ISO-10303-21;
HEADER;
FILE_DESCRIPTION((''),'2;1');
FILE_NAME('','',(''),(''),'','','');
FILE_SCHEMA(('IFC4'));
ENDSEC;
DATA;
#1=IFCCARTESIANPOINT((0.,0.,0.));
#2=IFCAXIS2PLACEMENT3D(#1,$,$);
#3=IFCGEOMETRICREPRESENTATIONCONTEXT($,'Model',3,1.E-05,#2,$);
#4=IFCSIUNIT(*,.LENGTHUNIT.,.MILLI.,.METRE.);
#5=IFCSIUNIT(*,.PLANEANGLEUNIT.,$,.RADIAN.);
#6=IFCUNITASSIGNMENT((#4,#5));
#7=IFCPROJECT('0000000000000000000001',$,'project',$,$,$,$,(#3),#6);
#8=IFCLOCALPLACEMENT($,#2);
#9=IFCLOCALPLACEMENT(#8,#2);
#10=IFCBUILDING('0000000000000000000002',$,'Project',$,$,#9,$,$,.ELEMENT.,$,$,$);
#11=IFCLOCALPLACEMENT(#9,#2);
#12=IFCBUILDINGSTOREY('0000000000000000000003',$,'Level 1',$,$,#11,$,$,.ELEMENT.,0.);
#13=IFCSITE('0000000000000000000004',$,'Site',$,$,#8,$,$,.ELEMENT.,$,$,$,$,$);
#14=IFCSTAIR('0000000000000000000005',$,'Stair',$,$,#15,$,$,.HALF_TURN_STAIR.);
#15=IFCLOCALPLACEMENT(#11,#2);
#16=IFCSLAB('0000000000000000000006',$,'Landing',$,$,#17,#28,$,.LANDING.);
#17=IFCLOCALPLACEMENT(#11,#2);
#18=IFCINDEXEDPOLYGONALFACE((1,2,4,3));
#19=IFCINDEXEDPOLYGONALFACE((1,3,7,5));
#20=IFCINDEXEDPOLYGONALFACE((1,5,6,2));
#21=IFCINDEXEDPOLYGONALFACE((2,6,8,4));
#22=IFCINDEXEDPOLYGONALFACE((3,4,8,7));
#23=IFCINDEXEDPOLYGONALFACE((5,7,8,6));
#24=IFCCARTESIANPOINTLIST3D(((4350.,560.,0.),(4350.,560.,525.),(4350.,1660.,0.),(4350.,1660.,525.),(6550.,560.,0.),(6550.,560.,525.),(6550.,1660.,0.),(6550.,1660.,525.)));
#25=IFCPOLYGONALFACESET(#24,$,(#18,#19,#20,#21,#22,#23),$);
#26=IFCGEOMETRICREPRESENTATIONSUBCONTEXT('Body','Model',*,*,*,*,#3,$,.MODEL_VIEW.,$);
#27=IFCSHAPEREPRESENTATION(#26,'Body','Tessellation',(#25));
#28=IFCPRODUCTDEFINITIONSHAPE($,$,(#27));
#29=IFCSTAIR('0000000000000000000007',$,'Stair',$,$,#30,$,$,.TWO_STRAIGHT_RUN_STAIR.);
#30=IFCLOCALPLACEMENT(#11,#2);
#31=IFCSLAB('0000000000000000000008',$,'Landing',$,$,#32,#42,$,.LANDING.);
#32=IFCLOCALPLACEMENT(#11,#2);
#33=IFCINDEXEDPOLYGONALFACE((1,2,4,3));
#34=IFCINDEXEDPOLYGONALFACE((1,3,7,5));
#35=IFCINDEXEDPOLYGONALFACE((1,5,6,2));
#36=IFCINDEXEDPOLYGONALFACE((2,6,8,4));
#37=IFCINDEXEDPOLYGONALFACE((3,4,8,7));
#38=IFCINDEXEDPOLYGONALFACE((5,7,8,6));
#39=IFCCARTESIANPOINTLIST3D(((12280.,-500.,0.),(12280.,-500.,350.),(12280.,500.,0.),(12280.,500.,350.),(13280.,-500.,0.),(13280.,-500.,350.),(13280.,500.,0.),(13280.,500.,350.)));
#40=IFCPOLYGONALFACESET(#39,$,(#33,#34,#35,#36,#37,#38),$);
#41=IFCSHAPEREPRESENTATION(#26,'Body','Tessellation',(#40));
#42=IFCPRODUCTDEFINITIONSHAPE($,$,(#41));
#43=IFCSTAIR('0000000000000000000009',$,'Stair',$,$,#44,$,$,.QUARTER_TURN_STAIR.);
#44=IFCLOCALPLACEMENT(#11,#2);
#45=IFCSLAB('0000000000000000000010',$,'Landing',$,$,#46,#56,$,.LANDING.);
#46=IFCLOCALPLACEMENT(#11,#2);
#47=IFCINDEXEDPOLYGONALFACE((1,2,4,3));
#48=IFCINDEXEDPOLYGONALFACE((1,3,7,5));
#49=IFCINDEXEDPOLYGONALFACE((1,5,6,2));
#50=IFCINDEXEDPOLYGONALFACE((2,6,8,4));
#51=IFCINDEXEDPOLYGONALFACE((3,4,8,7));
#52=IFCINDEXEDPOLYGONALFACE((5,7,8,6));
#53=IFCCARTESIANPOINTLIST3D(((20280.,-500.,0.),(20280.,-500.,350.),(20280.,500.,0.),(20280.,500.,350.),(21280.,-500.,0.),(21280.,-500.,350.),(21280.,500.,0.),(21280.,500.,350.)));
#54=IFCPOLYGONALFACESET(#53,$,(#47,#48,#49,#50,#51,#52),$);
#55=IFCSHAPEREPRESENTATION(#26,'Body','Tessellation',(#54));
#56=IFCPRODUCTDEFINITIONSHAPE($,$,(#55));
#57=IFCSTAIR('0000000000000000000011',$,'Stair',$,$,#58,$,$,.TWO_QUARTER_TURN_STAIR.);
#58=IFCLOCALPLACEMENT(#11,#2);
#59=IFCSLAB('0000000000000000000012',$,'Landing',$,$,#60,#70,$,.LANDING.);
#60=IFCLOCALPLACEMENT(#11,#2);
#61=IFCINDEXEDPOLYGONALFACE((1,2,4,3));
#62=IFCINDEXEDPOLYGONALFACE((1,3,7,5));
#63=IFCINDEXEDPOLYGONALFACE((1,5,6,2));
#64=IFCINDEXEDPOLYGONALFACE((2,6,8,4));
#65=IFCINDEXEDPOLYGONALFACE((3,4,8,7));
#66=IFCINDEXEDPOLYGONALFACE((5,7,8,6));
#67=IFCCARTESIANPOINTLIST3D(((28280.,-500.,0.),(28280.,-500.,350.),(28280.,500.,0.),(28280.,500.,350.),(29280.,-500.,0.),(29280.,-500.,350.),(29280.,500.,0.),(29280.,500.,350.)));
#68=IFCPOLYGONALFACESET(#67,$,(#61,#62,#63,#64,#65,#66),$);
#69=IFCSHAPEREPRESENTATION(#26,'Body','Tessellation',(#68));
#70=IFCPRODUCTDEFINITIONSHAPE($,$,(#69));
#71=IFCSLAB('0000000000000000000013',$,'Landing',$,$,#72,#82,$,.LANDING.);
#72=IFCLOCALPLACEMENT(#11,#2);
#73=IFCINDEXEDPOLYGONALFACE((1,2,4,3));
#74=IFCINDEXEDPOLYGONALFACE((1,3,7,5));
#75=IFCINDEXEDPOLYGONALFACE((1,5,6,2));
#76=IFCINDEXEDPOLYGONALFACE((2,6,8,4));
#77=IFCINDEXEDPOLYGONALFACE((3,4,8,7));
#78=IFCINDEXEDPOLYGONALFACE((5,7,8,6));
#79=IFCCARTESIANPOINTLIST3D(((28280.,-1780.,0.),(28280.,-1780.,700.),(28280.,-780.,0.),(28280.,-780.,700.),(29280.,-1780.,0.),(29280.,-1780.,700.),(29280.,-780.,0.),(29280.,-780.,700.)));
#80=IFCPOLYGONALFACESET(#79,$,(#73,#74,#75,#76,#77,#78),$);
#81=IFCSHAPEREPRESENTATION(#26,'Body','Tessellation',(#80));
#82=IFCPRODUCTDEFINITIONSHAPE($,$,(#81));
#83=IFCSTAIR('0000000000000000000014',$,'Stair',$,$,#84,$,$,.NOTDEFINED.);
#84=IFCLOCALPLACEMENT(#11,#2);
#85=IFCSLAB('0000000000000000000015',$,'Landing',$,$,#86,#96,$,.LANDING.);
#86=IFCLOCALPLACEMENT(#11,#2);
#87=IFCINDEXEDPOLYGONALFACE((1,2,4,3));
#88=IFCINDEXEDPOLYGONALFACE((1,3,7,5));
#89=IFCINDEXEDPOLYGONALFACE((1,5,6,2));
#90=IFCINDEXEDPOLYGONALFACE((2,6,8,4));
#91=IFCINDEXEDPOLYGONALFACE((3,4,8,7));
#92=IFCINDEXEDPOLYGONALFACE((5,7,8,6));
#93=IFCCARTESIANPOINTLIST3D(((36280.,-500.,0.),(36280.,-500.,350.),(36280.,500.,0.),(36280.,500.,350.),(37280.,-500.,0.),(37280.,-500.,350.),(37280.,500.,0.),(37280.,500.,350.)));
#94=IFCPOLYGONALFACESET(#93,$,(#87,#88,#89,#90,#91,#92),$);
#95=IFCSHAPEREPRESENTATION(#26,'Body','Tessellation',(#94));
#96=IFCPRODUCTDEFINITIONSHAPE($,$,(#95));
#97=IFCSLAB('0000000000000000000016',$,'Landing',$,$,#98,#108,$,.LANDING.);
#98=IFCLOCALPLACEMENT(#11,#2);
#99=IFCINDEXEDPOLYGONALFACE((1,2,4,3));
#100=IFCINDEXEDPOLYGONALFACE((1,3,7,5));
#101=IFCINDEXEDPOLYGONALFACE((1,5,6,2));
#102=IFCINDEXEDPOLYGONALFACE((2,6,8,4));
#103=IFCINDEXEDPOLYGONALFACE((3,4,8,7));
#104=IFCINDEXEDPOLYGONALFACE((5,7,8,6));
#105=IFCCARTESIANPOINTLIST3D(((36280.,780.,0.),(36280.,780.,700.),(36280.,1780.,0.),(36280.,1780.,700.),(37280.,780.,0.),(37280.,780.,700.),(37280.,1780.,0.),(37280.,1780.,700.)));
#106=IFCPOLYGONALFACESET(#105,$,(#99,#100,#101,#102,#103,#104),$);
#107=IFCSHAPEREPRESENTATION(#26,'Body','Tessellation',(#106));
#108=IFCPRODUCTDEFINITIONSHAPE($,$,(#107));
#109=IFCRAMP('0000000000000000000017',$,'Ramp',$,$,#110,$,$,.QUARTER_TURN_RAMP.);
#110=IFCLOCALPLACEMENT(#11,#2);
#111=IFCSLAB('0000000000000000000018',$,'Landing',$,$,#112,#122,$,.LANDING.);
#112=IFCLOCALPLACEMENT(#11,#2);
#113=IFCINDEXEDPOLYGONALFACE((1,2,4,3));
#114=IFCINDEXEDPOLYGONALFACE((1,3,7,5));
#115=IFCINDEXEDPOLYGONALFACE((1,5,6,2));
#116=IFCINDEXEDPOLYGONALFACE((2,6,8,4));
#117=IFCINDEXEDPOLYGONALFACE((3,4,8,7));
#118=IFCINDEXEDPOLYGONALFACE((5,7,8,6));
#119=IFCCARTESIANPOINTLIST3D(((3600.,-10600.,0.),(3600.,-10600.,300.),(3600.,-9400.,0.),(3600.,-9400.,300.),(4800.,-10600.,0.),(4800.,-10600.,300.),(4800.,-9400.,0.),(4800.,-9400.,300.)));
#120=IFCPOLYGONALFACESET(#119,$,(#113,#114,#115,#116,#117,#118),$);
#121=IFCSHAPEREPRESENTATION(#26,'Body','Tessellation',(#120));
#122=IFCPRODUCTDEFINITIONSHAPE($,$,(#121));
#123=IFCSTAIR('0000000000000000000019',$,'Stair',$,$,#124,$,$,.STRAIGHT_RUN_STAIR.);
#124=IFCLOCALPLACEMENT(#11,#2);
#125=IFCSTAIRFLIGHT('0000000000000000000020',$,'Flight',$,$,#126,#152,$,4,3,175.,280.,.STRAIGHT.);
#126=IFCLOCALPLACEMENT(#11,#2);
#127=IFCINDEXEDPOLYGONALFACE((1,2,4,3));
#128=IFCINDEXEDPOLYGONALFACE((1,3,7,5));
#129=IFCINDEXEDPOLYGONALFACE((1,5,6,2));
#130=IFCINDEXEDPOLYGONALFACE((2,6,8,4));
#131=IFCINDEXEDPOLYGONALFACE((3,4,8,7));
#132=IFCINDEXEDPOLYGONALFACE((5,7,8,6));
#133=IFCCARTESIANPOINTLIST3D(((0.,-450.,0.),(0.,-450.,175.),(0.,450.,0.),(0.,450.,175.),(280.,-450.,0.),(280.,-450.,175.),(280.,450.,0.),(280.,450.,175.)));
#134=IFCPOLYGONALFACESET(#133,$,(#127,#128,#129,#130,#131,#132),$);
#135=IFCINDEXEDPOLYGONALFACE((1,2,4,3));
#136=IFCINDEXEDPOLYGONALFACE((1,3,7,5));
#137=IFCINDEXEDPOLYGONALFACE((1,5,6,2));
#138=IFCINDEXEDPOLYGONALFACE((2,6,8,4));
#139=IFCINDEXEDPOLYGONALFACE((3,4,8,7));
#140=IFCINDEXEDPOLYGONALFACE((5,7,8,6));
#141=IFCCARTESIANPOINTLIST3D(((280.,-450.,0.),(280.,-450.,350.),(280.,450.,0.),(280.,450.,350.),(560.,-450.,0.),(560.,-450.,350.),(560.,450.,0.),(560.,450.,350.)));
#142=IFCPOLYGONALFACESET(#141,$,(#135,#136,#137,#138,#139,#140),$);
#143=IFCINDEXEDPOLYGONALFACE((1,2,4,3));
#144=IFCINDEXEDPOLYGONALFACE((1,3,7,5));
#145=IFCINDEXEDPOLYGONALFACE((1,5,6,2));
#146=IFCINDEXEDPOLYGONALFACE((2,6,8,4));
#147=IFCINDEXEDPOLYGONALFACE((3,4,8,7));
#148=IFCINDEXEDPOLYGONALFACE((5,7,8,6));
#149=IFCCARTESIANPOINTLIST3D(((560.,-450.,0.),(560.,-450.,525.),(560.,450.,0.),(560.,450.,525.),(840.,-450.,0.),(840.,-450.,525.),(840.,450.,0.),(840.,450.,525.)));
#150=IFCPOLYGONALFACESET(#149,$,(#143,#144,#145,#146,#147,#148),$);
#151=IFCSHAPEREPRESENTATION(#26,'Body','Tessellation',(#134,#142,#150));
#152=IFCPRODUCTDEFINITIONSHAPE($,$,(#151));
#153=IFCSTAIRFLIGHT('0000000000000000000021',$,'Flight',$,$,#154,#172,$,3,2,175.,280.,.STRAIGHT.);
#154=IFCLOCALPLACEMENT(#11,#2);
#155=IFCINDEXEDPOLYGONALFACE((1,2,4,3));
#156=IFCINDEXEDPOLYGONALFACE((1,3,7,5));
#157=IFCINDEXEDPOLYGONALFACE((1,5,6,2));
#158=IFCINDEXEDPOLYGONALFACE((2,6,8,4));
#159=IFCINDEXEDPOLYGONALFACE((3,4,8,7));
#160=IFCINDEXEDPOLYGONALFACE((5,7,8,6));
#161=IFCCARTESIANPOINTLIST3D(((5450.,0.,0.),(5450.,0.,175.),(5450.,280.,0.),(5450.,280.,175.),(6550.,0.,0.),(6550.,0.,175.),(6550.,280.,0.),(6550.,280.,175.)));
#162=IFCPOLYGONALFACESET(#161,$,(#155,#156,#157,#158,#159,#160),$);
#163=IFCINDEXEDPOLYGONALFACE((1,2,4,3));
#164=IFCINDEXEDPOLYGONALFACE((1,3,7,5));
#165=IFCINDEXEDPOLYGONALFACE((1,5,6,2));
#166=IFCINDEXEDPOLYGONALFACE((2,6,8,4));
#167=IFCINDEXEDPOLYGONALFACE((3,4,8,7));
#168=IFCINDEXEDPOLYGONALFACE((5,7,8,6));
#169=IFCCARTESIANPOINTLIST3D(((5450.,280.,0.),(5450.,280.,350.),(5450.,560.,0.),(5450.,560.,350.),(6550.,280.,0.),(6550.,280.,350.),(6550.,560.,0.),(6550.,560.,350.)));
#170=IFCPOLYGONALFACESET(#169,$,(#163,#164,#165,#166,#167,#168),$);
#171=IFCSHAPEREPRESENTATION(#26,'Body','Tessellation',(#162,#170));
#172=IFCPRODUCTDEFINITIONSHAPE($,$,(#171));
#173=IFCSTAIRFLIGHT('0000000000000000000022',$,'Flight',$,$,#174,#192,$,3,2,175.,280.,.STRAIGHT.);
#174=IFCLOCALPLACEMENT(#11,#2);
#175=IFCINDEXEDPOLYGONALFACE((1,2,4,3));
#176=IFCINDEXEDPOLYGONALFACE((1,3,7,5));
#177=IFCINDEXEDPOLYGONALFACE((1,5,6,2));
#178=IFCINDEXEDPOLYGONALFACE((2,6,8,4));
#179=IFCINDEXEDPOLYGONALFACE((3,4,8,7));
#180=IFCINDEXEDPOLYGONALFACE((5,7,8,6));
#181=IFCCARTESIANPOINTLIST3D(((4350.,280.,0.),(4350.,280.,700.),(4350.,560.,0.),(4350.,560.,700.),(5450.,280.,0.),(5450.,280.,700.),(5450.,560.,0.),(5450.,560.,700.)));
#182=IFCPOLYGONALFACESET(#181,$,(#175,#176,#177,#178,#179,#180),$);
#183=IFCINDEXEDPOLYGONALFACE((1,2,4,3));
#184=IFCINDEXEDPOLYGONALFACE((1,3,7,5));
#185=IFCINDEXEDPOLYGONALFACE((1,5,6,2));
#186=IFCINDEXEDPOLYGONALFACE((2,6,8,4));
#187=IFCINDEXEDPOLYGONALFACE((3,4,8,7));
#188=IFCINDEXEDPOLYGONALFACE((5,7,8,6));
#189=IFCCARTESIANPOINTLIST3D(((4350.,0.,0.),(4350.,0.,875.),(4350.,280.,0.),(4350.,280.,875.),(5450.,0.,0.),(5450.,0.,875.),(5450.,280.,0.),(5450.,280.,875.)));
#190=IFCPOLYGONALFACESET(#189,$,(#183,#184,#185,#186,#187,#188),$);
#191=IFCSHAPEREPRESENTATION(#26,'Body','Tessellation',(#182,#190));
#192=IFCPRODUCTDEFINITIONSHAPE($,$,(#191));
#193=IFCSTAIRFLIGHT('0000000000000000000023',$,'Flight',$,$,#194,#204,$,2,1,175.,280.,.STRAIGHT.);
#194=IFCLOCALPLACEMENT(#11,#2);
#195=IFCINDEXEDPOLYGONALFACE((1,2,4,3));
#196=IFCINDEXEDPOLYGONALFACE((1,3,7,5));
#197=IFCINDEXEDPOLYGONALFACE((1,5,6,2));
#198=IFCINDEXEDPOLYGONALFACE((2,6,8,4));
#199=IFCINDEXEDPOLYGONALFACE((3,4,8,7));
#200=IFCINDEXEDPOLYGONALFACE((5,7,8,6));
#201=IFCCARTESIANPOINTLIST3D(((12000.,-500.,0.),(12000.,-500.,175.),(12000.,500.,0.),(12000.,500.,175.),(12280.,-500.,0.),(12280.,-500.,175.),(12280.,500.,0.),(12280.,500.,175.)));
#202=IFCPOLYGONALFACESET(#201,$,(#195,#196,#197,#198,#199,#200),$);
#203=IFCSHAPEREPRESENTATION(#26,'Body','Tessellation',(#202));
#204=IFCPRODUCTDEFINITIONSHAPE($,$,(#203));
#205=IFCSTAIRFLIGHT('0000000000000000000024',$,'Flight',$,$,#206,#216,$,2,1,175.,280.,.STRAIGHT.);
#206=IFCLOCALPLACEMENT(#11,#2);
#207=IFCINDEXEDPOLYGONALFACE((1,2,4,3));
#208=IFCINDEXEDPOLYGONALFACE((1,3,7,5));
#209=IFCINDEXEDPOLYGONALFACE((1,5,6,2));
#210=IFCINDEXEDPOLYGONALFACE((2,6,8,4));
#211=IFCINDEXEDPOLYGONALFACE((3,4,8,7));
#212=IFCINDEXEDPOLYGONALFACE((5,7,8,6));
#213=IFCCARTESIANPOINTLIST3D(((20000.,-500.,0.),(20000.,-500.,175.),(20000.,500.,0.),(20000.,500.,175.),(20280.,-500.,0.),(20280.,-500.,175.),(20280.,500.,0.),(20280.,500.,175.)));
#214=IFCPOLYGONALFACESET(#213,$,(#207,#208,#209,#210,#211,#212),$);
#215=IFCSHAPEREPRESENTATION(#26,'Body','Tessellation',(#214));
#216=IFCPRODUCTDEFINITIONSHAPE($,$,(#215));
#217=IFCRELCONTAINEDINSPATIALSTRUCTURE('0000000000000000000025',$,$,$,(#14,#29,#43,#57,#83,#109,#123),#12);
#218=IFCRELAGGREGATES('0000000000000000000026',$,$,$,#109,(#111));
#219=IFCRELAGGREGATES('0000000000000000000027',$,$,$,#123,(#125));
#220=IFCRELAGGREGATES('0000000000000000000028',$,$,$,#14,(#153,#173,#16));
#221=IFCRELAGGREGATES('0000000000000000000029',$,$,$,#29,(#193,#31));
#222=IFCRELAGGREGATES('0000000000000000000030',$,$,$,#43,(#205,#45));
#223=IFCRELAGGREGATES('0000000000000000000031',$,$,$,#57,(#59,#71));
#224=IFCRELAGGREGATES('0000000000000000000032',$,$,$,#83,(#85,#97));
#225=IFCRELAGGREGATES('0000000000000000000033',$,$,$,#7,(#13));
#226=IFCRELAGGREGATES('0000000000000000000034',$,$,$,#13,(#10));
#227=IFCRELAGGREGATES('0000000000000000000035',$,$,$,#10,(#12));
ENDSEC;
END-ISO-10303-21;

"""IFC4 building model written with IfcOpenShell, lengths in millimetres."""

from ifc_helpers import new_model, si_unit, frame, frame_2d, origin, origin_with_axes, place, context, subcontext, project, spatial, polyline, rectangle, outline, extrude, element, aggregate, save


model = new_model("IFC4")

# Units and contexts
model_context = context("Model", 3, precision=1e-05, world=origin())
body_context = subcontext(model_context, "Body", "Model", "MODEL_VIEW")
ifc_project = project(units=[si_unit("LENGTHUNIT", "METRE", prefix="MILLI"), si_unit("PLANEANGLEUNIT", "RADIAN")], contexts=[model_context])

# Site, building, storey
site_placement = place(None, origin())
site = spatial("IfcSite", under=ifc_project, at=site_placement, Name="Site", CompositionType="ELEMENT")
building_placement = place(site_placement, origin())
building = spatial("IfcBuilding", under=site, at=building_placement, Name="Project", CompositionType="ELEMENT")
storey_placement = place(building_placement, origin())
storey = spatial("IfcBuildingStorey", under=building, at=storey_placement, Name="Level 1", CompositionType="ELEMENT", Elevation=0.0)

# Stairs, slabs
stair_1_placement = place(storey_placement, origin())
stair_1 = element("IfcStair", 1, at=stair_1_placement, inside=storey, Name="Stair", PredefinedType="HALF_TURN_STAIR")
slab_1_placement = place(stair_1_placement, origin())
slab_1 = element("IfcSlab", 2, at=slab_1_placement, Name="Landing", PredefinedType="LANDING", context=body_context, shape_type="SweptSolid", body=[
    extrude(outline(polyline([(6550.0, 560.0), (6550.0, 1660.0), (4350.0, 1660.0), (4350.0, 560.0), (6550.0, 560.0)])), origin(), (0.0, 0.0, 1.0), 525.0),
])
stair_2_placement = place(storey_placement, origin())
stair_2 = element("IfcStair", 3, at=stair_2_placement, inside=storey, Name="Stair", PredefinedType="TWO_STRAIGHT_RUN_STAIR")
slab_2_placement = place(stair_2_placement, origin())
slab_2 = element("IfcSlab", 4, at=slab_2_placement, Name="Landing", PredefinedType="LANDING", context=body_context, shape_type="SweptSolid", body=[
    extrude(outline(polyline([(12280.0, -500.0), (13280.0, -500.0), (13280.0, 500.0), (12280.0, 500.0), (12280.0, -500.0)])), origin(), (0.0, 0.0, 1.0), 350.0),
])
stair_3_placement = place(storey_placement, origin())
stair_3 = element("IfcStair", 5, at=stair_3_placement, inside=storey, Name="Stair", PredefinedType="QUARTER_TURN_STAIR")
slab_3_placement = place(stair_3_placement, origin())
slab_3 = element("IfcSlab", 6, at=slab_3_placement, Name="Landing", PredefinedType="LANDING", context=body_context, shape_type="SweptSolid", body=[
    extrude(outline(polyline([(20280.0, -500.0), (21280.0, -500.0), (21280.0, 500.0), (20280.0, 500.0), (20280.0, -500.0)])), origin(), (0.0, 0.0, 1.0), 350.0),
])

# Stairs, slabs
stair_4_placement = place(storey_placement, origin())
stair_4 = element("IfcStair", 7, at=stair_4_placement, inside=storey, Name="Stair", PredefinedType="TWO_QUARTER_TURN_STAIR")
slab_4_placement = place(stair_4_placement, origin())
slab_4 = element("IfcSlab", 8, at=slab_4_placement, Name="Landing", PredefinedType="LANDING", context=body_context, shape_type="SweptSolid", body=[
    extrude(outline(polyline([(28280.0, -500.0), (29280.0, -500.0), (29280.0, 500.0), (28280.0, 500.0), (28280.0, -500.0)])), origin(), (0.0, 0.0, 1.0), 350.0),
])
slab_5_placement = place(stair_4_placement, origin())
slab_5 = element("IfcSlab", 9, at=slab_5_placement, Name="Landing", PredefinedType="LANDING", context=body_context, shape_type="SweptSolid", body=[
    extrude(outline(polyline([(28280.0, -780.0), (28280.0, -1780.0), (29280.0, -1780.0), (29280.0, -780.0), (28280.0, -780.0)])), origin(), (0.0, 0.0, 1.0), 700.0),
])
stair_5_placement = place(storey_placement, origin())
stair_5 = element("IfcStair", 10, at=stair_5_placement, inside=storey, Name="Stair", PredefinedType="NOTDEFINED")
slab_6_placement = place(stair_5_placement, origin())
slab_6 = element("IfcSlab", 11, at=slab_6_placement, Name="Landing", PredefinedType="LANDING", context=body_context, shape_type="SweptSolid", body=[
    extrude(outline(polyline([(36280.0, -500.0), (37280.0, -500.0), (37280.0, 500.0), (36280.0, 500.0), (36280.0, -500.0)])), origin(), (0.0, 0.0, 1.0), 350.0),
])
slab_7_placement = place(stair_5_placement, origin())
slab_7 = element("IfcSlab", 12, at=slab_7_placement, Name="Landing", PredefinedType="LANDING", context=body_context, shape_type="SweptSolid", body=[
    extrude(outline(polyline([(37280.0, 780.0), (37280.0, 1780.0), (36280.0, 1780.0), (36280.0, 780.0), (37280.0, 780.0)])), origin(), (0.0, 0.0, 1.0), 700.0),
])

# Ramp, slab
ramp_placement = place(storey_placement, origin())
ramp = element("IfcRamp", 13, at=ramp_placement, inside=storey, Name="Ramp", PredefinedType="QUARTER_TURN_RAMP")
slab_8_placement = place(ramp_placement, origin())
slab_8 = element("IfcSlab", 14, at=slab_8_placement, Name="Landing", PredefinedType="LANDING", context=body_context, shape_type="SweptSolid", body=[
    extrude(outline(polyline([(3600.0, -10600.0), (4800.0, -10600.0), (4800.0, -9400.0), (3600.0, -9400.0), (3600.0, -10600.0)])), origin(), (0.0, 0.0, 1.0), 300.0),
])
aggregate(ramp, [slab_8])

# Stair, stair flight
stair_6_placement = place(storey_placement, origin())
stair_6 = element("IfcStair", 15, at=stair_6_placement, inside=storey, Name="Stair", PredefinedType="STRAIGHT_RUN_STAIR")
stair_flight_1_placement = place(stair_6_placement, origin_with_axes())
stair_flight_1 = element("IfcStairFlight", 16, at=stair_flight_1_placement, Name="Flight", NumberOfRisers=4, NumberOfTreads=3, PredefinedType="STRAIGHT", RiserHeight=175.0, TreadLength=280.0, context=body_context, shape_type="SweptSolid", body=[
    extrude(rectangle(XDim=280.0, YDim=900.0, at=frame_2d((140.0, 0.0))), origin(), (0.0, 0.0, 1.0), 175.0),
    extrude(rectangle(XDim=280.0, YDim=900.0, at=frame_2d((420.0, 0.0))), origin(), (0.0, 0.0, 1.0), 350.0),
    extrude(rectangle(XDim=280.0, YDim=900.0, at=frame_2d((700.0, 0.0))), origin(), (0.0, 0.0, 1.0), 525.0),
])
aggregate(stair_6, [stair_flight_1])

# Stair flights
stair_flight_2_placement = place(stair_1_placement, frame((6000.0, 0.0, 0.0), z_axis=(0.0, 0.0, 1.0), x_axis=(0.0, 1.0, 0.0)))
stair_flight_2 = element("IfcStairFlight", 17, at=stair_flight_2_placement, Name="Flight", NumberOfRisers=3, NumberOfTreads=2, PredefinedType="STRAIGHT", RiserHeight=175.0, TreadLength=280.0, context=body_context, shape_type="SweptSolid", body=[
    extrude(rectangle(XDim=280.0, YDim=1100.0, at=frame_2d((140.0, 0.0))), origin(), (0.0, 0.0, 1.0), 175.0),
    extrude(rectangle(XDim=280.0, YDim=1100.0, at=frame_2d((420.0, 0.0))), origin(), (0.0, 0.0, 1.0), 350.0),
])
stair_flight_3_placement = place(stair_1_placement, frame((4900.0, 560.0, 525.0), z_axis=(0.0, 0.0, 1.0), x_axis=(0.0, -1.0, 0.0)))
stair_flight_3 = element("IfcStairFlight", 18, at=stair_flight_3_placement, Name="Flight", NumberOfRisers=3, NumberOfTreads=2, PredefinedType="STRAIGHT", RiserHeight=175.0, TreadLength=280.0, context=body_context, shape_type="SweptSolid", body=[
    extrude(rectangle(XDim=280.0, YDim=1100.0, at=frame_2d((140.0, 0.0))), frame((0.0, 0.0, -525.0)), (0.0, 0.0, 1.0), 700.0),
    extrude(rectangle(XDim=280.0, YDim=1100.0, at=frame_2d((420.0, 0.0))), frame((0.0, 0.0, -525.0)), (0.0, 0.0, 1.0), 875.0),
])
aggregate(stair_1, [stair_flight_2, stair_flight_3, slab_1])
stair_flight_4_placement = place(stair_2_placement, frame((12000.0, 0.0, 0.0), z_axis=(0.0, 0.0, 1.0), x_axis=(1.0, 0.0, 0.0)))
stair_flight_4 = element("IfcStairFlight", 19, at=stair_flight_4_placement, Name="Flight", NumberOfRisers=2, NumberOfTreads=1, PredefinedType="STRAIGHT", RiserHeight=175.0, TreadLength=280.0, context=body_context, shape_type="SweptSolid", body=[
    extrude(rectangle(XDim=280.0, YDim=1000.0, at=frame_2d((140.0, 0.0))), origin(), (0.0, 0.0, 1.0), 175.0),
])
aggregate(stair_2, [stair_flight_4, slab_2])
stair_flight_5_placement = place(stair_3_placement, frame((20000.0, 0.0, 0.0), z_axis=(0.0, 0.0, 1.0), x_axis=(1.0, 0.0, 0.0)))
stair_flight_5 = element("IfcStairFlight", 20, at=stair_flight_5_placement, Name="Flight", NumberOfRisers=2, NumberOfTreads=1, PredefinedType="STRAIGHT", RiserHeight=175.0, TreadLength=280.0, context=body_context, shape_type="SweptSolid", body=[
    extrude(rectangle(XDim=280.0, YDim=1000.0, at=frame_2d((140.0, 0.0))), origin(), (0.0, 0.0, 1.0), 175.0),
])
aggregate(stair_3, [stair_flight_5, slab_3])
aggregate(stair_4, [slab_4, slab_5])
aggregate(stair_5, [slab_6, slab_7])

save(model, "model.ifc")
